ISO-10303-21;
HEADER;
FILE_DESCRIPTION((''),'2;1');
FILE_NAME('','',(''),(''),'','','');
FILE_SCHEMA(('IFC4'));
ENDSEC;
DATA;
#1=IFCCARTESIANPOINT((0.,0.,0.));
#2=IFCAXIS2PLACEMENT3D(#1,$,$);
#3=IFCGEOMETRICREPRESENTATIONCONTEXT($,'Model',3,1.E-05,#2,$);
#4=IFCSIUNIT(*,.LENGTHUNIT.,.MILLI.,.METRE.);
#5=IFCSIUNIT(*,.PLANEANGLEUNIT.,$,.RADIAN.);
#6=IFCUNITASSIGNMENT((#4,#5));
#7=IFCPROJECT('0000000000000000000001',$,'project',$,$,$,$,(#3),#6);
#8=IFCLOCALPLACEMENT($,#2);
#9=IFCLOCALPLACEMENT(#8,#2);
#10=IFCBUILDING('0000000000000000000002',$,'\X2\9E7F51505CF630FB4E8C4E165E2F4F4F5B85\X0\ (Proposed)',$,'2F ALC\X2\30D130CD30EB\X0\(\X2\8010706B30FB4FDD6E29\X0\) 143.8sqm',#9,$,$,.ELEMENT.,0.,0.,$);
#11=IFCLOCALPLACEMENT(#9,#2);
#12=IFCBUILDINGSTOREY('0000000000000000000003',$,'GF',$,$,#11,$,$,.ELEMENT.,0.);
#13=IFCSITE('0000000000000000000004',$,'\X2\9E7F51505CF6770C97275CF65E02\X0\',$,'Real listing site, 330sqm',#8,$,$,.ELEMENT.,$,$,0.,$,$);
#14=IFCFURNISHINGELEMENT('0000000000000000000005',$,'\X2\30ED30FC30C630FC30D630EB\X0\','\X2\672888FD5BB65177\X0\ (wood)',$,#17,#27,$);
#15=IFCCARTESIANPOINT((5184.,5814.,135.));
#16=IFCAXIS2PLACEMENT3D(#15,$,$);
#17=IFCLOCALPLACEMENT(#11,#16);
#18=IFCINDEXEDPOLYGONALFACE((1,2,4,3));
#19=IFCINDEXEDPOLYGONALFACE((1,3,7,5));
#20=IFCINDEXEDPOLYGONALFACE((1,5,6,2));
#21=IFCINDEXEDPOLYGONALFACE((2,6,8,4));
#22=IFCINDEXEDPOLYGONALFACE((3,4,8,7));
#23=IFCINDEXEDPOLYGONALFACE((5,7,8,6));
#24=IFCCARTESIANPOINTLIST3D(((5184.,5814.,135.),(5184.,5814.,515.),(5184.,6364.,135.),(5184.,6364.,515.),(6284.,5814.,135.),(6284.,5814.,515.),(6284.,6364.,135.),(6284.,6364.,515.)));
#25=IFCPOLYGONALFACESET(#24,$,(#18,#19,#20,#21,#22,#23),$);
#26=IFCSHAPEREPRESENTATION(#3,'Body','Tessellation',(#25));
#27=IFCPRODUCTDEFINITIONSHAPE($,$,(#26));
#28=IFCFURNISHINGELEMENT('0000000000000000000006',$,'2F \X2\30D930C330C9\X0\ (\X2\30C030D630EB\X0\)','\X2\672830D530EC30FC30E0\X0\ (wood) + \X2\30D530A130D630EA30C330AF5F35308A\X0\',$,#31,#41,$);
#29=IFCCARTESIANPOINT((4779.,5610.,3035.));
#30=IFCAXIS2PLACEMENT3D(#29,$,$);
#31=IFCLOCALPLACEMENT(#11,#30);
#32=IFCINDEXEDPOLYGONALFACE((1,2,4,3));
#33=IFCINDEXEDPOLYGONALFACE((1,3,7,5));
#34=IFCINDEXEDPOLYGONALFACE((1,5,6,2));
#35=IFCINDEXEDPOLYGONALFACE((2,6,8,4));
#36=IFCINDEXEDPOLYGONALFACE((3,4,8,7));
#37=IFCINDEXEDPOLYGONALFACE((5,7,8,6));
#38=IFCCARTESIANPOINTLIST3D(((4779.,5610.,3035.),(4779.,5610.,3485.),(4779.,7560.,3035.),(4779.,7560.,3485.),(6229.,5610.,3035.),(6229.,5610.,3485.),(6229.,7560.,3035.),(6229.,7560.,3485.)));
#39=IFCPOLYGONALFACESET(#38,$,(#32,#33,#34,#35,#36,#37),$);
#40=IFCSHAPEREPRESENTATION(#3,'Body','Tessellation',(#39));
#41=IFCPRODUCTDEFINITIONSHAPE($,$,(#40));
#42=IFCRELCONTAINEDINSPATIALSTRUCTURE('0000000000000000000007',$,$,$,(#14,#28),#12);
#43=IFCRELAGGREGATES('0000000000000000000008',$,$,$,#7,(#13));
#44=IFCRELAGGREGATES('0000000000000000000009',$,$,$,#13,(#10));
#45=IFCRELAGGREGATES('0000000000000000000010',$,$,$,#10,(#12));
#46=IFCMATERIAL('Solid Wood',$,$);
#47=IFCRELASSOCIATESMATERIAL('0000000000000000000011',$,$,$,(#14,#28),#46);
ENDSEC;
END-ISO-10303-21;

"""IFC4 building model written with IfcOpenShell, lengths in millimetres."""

from ifc_helpers import new_model, si_unit, frame, frame_2d, origin, place, context, project, spatial, rectangle, extrude, material, element, save


model = new_model("IFC4")

# Units and contexts
model_context = context("Model", 3, precision=1e-05, world=origin())
ifc_project = project(units=[si_unit("LENGTHUNIT", "METRE", prefix="MILLI"), si_unit("PLANEANGLEUNIT", "RADIAN")], contexts=[model_context])

# Site, building, storey
site_placement = place(None, origin())
site = spatial("IfcSite", under=ifc_project, at=site_placement, Name="鹿児島県霧島市", ObjectType="Real listing site, 330sqm", CompositionType="ELEMENT", RefElevation=0.0)
building_placement = place(site_placement, origin())
building = spatial("IfcBuilding", under=site, at=building_placement, Name="鹿児島・二世帯住宅 (Proposed)", ObjectType="2F ALCパネル(耐火・保温) 143.8sqm", CompositionType="ELEMENT", ElevationOfRefHeight=0.0, ElevationOfTerrain=0.0)
storey_placement = place(building_placement, origin())
storey = spatial("IfcBuildingStorey", under=building, at=storey_placement, Name="GF", CompositionType="ELEMENT", Elevation=0.0)

# Shared definitions
ifc_material_1 = material(Name="Solid Wood")

# Furnishing elements
furnishing_1_placement = place(storey_placement, frame((5184.0, 5814.0, 135.0)))
element("IfcFurnishingElement", 1, at=furnishing_1_placement, inside=storey, material=ifc_material_1, Name="ローテーブル", Description="木製家具 (wood)", context=model_context, shape_type="SweptSolid", body=[
    extrude(rectangle(XDim=1100.0, YDim=550.0, at=frame_2d((550.0, 275.0))), frame((5184.0, 5814.0, 135.0)), (0.0, 0.0, 1.0), 380.0),
])
furnishing_2_placement = place(storey_placement, frame((4779.0, 5610.0, 3035.0)))
element("IfcFurnishingElement", 2, at=furnishing_2_placement, inside=storey, material=ifc_material_1, Name="2F ベッド (ダブル)", Description="木フレーム (wood) + ファブリック張り", context=model_context, shape_type="SweptSolid", body=[
    extrude(rectangle(XDim=1450.0, YDim=1950.0, at=frame_2d((725.0, 975.0))), frame((4779.0, 5610.0, 3035.0)), (0.0, 0.0, 1.0), 450.0),
])

save(model, "model.ifc")
